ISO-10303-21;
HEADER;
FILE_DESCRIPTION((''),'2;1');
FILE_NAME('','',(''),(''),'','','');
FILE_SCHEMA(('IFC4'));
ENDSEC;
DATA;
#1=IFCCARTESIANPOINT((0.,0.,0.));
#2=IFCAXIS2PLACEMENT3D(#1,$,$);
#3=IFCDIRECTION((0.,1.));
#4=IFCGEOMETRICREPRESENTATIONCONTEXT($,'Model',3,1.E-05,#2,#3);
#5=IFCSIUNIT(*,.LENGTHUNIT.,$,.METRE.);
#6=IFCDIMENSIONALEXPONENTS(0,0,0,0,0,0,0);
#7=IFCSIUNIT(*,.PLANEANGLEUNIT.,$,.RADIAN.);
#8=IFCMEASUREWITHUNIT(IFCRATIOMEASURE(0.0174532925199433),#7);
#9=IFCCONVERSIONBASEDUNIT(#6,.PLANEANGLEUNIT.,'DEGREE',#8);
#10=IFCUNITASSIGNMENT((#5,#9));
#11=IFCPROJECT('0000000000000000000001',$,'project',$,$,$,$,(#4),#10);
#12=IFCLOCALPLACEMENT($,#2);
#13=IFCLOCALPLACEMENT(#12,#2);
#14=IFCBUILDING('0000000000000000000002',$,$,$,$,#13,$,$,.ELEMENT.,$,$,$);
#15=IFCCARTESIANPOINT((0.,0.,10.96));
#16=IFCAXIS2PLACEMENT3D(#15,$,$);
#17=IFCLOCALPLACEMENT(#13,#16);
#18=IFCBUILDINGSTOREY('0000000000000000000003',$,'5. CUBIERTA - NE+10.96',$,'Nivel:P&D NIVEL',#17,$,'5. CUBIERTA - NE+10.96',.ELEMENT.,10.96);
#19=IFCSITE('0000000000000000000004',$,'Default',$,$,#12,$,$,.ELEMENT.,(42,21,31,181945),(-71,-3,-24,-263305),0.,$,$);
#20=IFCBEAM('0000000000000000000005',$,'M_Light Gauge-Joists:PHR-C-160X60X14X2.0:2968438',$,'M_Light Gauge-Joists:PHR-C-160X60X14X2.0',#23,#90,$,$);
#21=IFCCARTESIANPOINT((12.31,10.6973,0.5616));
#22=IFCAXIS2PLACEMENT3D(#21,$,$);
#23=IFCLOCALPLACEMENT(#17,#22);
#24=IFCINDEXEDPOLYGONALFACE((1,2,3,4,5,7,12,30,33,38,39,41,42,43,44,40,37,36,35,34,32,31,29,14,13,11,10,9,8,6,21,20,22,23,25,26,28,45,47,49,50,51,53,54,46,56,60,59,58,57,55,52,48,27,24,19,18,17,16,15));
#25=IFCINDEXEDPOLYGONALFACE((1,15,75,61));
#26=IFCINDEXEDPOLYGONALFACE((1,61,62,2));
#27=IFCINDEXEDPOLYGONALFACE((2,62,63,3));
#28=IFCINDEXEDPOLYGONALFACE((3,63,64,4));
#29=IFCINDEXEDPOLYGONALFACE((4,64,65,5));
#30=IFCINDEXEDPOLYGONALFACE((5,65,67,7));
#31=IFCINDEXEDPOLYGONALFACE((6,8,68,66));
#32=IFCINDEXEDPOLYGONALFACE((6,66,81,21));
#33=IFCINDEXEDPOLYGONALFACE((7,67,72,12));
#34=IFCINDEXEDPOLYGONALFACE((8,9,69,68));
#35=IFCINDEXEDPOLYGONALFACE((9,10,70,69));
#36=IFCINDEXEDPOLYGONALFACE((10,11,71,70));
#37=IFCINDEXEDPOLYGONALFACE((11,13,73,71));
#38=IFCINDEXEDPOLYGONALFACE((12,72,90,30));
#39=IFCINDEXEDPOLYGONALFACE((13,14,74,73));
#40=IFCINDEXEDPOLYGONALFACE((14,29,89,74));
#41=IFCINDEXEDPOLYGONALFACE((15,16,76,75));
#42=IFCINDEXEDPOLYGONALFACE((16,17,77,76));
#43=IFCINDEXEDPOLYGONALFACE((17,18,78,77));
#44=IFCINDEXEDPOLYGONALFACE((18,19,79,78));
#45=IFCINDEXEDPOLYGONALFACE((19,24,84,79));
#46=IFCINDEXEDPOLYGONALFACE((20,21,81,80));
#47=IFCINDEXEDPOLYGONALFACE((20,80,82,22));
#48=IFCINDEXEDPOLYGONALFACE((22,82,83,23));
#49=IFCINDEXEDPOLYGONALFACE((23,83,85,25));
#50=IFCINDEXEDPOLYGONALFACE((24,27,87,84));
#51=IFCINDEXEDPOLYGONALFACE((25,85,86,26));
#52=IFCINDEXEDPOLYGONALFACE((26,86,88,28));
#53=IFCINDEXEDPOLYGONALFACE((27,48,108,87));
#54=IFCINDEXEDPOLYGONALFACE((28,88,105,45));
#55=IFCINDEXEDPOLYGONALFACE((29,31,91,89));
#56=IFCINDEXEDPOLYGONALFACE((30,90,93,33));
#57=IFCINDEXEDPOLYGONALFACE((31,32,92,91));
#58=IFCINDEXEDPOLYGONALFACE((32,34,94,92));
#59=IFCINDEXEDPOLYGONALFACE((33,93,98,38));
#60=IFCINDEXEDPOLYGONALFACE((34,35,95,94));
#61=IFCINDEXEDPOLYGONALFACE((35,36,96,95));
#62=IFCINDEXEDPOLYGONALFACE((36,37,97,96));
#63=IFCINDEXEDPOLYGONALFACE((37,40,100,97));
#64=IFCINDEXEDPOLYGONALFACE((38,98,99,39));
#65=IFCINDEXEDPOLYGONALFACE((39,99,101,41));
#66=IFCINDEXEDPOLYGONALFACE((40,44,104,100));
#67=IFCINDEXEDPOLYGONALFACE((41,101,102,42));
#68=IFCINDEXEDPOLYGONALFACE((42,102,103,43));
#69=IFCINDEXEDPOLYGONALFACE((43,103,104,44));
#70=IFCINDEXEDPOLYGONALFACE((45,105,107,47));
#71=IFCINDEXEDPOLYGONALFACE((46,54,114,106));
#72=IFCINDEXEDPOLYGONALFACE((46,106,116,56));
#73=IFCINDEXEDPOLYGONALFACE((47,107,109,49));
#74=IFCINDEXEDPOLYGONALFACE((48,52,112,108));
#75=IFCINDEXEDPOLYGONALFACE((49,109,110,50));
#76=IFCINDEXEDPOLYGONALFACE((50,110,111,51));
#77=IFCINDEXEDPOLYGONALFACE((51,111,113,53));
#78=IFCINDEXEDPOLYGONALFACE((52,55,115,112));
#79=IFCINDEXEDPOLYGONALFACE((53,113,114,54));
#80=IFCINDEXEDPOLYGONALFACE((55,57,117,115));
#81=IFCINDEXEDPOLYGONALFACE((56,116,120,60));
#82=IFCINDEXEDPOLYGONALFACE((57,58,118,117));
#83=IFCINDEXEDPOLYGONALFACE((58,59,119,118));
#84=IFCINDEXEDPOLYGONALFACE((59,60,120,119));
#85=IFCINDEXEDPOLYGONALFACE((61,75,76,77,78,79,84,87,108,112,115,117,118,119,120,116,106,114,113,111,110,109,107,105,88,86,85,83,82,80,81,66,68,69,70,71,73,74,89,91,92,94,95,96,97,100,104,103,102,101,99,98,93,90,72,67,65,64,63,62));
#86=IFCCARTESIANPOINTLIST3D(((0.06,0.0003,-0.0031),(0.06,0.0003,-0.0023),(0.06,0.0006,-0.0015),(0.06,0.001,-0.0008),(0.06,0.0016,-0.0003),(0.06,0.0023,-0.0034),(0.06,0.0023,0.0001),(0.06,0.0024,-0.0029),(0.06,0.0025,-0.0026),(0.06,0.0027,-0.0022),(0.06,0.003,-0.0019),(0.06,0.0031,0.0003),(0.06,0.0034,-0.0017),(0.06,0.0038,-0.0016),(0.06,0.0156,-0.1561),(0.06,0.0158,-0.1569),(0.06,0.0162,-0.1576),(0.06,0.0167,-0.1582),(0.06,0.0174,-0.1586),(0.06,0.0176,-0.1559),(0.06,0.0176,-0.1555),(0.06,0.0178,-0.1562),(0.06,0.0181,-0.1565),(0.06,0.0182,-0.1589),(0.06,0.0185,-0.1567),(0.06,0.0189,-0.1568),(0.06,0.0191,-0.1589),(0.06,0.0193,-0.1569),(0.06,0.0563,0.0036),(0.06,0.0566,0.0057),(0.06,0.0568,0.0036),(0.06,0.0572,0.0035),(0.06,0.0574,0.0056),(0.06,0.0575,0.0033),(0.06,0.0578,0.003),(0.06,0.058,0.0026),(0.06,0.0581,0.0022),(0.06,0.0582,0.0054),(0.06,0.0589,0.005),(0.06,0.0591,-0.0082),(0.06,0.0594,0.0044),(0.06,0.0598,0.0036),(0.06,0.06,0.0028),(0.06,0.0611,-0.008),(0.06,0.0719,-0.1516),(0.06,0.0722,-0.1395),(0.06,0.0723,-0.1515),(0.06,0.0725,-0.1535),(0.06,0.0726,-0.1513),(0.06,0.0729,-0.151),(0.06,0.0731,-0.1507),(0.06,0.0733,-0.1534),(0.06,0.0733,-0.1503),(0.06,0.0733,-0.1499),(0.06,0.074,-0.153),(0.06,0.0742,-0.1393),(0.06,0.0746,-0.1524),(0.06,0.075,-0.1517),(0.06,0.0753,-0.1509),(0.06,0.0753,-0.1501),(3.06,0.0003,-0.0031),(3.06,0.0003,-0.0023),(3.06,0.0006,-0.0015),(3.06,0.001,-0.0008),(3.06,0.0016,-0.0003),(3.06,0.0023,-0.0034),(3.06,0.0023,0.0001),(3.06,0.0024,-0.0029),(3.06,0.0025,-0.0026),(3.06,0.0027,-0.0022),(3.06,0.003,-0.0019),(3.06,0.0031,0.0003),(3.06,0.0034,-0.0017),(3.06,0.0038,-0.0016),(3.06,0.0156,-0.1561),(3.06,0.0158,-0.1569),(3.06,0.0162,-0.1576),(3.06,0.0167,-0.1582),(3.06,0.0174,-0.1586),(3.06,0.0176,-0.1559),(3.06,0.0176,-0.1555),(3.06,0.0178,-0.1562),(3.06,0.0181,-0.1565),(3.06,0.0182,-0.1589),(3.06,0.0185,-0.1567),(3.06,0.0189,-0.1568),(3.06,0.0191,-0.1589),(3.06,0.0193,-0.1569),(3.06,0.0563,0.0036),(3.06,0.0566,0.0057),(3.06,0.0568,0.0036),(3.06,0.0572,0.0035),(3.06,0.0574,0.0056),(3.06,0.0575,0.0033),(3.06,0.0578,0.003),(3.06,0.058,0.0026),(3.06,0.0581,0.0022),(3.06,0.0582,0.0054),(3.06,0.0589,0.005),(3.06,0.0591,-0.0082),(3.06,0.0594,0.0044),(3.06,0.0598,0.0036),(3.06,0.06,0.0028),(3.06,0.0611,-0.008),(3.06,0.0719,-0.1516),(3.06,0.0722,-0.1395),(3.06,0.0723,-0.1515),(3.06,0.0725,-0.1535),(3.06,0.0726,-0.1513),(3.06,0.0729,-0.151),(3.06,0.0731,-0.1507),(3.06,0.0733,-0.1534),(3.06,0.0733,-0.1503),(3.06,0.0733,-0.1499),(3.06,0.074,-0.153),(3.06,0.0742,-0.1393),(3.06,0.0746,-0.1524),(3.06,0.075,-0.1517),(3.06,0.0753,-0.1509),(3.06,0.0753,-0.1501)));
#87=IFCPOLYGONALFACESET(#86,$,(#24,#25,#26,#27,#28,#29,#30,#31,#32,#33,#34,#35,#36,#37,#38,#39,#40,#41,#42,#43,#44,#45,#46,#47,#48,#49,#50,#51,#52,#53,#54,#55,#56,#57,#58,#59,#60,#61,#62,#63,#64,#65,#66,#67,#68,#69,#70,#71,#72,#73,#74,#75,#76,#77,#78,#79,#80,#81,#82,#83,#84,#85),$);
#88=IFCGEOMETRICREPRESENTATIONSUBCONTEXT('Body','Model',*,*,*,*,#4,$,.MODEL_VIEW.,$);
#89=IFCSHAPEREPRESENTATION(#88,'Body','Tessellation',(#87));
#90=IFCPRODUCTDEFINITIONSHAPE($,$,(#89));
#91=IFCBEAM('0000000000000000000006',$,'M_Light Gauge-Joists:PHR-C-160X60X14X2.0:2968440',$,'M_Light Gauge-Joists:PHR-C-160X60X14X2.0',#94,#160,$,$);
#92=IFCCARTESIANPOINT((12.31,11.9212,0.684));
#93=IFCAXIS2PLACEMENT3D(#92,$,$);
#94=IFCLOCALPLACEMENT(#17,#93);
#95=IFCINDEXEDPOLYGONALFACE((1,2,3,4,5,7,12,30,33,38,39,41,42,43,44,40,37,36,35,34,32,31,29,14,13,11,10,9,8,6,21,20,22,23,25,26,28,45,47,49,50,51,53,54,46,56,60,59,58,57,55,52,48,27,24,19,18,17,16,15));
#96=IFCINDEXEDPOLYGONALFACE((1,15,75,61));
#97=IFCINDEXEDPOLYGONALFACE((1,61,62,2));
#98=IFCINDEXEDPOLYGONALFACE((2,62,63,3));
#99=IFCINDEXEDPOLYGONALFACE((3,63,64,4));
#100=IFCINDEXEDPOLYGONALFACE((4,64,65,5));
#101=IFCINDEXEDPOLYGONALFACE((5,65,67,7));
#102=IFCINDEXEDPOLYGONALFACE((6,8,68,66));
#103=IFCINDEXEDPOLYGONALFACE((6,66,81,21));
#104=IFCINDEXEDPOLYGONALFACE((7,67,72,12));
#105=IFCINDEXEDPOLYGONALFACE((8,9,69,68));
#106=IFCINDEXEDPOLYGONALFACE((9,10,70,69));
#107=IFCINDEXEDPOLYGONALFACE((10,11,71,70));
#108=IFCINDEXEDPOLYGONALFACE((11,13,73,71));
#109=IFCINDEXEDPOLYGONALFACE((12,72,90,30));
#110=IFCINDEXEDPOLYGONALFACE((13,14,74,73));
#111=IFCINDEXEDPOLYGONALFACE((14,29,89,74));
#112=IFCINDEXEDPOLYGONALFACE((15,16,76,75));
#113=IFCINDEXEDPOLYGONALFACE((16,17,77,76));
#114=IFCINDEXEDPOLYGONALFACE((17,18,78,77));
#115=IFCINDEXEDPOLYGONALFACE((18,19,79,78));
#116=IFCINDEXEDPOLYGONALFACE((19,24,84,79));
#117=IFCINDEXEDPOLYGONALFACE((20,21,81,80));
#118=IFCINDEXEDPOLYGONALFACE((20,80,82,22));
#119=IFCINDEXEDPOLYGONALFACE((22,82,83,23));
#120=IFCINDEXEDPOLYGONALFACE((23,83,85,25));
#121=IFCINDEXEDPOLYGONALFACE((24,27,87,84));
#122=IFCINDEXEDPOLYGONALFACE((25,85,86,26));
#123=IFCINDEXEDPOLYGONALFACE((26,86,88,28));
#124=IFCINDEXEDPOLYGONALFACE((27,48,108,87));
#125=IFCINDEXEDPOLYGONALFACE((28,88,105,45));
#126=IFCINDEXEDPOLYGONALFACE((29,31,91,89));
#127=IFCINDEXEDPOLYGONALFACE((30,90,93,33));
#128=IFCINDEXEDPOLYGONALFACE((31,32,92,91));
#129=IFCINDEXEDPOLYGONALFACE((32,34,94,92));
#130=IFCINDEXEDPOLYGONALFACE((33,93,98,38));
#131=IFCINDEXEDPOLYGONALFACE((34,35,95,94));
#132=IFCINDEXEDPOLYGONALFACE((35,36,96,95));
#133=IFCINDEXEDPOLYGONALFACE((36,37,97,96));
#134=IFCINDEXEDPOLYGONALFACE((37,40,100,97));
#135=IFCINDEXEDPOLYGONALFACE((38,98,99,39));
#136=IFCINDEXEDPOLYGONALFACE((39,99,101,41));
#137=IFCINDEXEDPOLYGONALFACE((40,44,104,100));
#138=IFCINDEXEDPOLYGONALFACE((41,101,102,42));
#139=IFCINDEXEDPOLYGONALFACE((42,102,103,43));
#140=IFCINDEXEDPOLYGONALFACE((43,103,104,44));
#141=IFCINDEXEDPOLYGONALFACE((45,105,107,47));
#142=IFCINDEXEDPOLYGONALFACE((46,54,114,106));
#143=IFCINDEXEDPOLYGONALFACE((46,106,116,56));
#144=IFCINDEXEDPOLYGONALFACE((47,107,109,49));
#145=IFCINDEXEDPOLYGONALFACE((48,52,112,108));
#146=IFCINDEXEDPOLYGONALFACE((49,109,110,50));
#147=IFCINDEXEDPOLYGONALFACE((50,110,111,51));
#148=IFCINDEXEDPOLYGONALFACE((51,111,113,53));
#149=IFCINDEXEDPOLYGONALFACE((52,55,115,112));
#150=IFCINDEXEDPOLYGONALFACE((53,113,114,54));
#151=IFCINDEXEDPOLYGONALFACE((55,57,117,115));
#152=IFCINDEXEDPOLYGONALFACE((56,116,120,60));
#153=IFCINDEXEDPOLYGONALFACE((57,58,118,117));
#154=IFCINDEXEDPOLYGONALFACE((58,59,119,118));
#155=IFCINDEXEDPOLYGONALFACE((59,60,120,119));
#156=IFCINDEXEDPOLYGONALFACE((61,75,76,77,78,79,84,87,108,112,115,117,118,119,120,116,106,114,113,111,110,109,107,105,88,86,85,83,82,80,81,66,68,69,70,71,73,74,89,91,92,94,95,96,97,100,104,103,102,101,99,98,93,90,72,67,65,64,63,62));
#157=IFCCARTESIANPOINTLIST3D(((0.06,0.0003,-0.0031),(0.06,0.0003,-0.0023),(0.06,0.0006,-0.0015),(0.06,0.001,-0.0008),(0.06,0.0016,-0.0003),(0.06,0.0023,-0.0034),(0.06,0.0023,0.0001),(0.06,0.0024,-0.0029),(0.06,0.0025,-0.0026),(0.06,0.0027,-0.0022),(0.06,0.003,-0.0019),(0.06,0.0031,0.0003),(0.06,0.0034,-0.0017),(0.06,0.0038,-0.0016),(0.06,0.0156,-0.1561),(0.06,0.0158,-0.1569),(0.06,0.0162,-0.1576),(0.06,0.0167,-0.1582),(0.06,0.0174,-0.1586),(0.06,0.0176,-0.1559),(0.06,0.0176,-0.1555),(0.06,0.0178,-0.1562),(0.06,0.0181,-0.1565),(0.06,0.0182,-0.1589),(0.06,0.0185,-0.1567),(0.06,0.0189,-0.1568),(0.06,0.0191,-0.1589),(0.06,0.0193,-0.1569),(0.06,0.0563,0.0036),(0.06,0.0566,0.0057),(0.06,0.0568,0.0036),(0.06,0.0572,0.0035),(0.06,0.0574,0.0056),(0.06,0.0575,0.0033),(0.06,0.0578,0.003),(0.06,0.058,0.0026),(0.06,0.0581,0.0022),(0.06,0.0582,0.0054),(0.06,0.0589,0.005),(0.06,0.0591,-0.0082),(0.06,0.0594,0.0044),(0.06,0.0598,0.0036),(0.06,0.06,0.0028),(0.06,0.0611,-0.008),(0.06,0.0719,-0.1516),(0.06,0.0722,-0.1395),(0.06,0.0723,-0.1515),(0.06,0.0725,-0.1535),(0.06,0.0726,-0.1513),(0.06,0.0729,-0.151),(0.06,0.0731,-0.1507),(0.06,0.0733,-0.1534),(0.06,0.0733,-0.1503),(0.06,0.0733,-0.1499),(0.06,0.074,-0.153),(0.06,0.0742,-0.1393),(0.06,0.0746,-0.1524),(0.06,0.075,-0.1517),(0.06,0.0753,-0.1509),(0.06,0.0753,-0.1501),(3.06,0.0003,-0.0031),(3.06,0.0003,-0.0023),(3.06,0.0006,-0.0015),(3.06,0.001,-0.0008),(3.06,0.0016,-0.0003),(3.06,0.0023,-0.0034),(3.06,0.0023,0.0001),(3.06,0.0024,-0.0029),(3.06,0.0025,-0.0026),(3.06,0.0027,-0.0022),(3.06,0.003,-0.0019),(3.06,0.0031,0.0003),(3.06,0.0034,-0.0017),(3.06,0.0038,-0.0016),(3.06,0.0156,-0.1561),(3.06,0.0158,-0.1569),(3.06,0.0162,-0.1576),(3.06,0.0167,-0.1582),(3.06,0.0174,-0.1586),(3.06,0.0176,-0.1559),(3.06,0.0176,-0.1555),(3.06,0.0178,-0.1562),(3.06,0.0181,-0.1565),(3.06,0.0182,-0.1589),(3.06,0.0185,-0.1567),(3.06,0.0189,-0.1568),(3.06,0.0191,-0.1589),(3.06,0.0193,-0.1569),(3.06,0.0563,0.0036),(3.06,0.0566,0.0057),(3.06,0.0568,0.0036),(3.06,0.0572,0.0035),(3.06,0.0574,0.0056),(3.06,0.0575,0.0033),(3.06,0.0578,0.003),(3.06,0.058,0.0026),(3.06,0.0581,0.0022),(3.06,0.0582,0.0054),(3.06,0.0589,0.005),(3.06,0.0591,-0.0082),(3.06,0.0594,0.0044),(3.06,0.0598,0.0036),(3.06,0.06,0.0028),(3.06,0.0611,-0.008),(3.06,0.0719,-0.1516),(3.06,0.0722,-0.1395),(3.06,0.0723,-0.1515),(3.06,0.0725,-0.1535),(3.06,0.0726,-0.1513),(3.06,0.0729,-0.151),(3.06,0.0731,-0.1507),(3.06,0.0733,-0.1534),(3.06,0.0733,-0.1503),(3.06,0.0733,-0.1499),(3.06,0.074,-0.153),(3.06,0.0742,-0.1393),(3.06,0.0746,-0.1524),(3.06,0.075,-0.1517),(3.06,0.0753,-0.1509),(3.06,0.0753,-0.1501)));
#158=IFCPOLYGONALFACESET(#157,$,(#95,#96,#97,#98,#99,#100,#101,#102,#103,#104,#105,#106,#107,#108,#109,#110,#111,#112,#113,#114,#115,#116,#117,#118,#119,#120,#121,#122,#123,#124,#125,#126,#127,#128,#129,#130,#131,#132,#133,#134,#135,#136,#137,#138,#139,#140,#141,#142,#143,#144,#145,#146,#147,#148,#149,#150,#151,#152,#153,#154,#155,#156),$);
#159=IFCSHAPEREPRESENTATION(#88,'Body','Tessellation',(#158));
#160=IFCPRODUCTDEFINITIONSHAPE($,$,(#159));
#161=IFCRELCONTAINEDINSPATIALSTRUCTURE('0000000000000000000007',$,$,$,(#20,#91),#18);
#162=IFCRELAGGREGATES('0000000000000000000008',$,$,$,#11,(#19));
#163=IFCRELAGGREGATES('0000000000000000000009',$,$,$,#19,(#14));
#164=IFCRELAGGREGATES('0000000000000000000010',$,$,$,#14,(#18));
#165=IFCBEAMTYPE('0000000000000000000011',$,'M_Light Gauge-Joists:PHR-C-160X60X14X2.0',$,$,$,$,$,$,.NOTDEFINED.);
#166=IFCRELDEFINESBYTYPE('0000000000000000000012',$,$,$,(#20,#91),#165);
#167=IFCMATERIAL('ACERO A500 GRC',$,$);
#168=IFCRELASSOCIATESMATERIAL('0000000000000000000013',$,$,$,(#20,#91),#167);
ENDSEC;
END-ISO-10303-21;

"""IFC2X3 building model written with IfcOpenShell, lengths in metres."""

from ifc_helpers import new_model, entity, si_unit, converted_unit, direction, frame, frame_2d, origin, place, context, subcontext, project, spatial, polyline, circle_curve, parameter, trimmed, segment, composite_curve, outline, extrude, material, type_object, element, save


model = new_model("IFC2X3")

# Units and contexts
model_context = context("Model", 3, precision=1e-05, world=origin(), true_north=direction((0.0, 1.0)))
body_context = subcontext(model_context, "Body", "Model", "MODEL_VIEW")
ifc_project = project(units=[si_unit("LENGTHUNIT", "METRE"), converted_unit("PLANEANGLEUNIT", "DEGREE", entity("IfcRatioMeasure", 0.0174532925199433), si_unit("PLANEANGLEUNIT", "RADIAN"), dimensions=[0, 0, 0, 0, 0, 0, 0])], contexts=[model_context])

# Site, building, storey
site_placement = place(None, origin())
site = spatial("IfcSite", under=ifc_project, at=site_placement, Name="Default", CompositionType="ELEMENT", RefLatitude=(42, 21, 31, 181945), RefLongitude=(-71, -3, -24, -263305), RefElevation=0.0)
building_placement = place(site_placement, origin())
building = spatial("IfcBuilding", under=site, at=building_placement, CompositionType="ELEMENT")
storey_placement = place(building_placement, frame((0.0, 0.0, 10.96)))
storey = spatial("IfcBuildingStorey", under=building, at=storey_placement, Name="5. CUBIERTA - NE+10.96", ObjectType="Nivel:P&D NIVEL", LongName="5. CUBIERTA - NE+10.96", CompositionType="ELEMENT", Elevation=10.96)

# Beams
ifc_material_1 = material(Name="ACERO A500 GRC")
beam_type_1 = type_object("IfcBeamType", Name="M_Light Gauge-Joists:PHR-C-160X60X14X2.0", PredefinedType="NOTDEFINED")
beam_1_placement = place(storey_placement, frame((12.31, 10.6973, 0.5616)))
element("IfcBeam", 1, at=beam_1_placement, inside=storey, type_object=beam_type_1, material=ifc_material_1, Name="M_Light Gauge-Joists:PHR-C-160X60X14X2.0:2968438", ObjectType="M_Light Gauge-Joists:PHR-C-160X60X14X2.0", context=body_context, shape_type="SweptSolid", body=[
    extrude(outline(composite_curve([segment(trimmed(circle_curve(frame_2d((-0.0764, -0.0322), x_axis=(-1.0, 0.0)), 0.0016), [parameter(0.0)], [parameter(90.0)], True, "PARAMETER"), False, "CONTINUOUS"), segment(polyline([(-0.078, -0.0322), (-0.078, 0.0206)]), True, "CONTINUOUS"), segment(trimmed(circle_curve(frame_2d((-0.0764, 0.0206), x_axis=(0.0, 1.0)), 0.0016), [parameter(0.0)], [parameter(90.0)], True, "PARAMETER"), False, "CONTINUOUS"), segment(polyline([(-0.0764, 0.0222), (-0.066, 0.0222)]), True, "CONTINUOUS"), segment(polyline([(-0.066, 0.0222), (-0.066, 0.0242)]), True, "CONTINUOUS"), segment(polyline([(-0.066, 0.0242), (-0.0768, 0.0242)]), True, "CONTINUOUS"), segment(trimmed(circle_curve(frame_2d((-0.0768, 0.021), x_axis=(-1.0, 0.0)), 0.0032), [parameter(270.0)], [parameter(0.0)], True, "PARAMETER"), True, "CONTINUOUS"), segment(polyline([(-0.08, 0.021), (-0.08, -0.0326)]), True, "CONTINUOUS"), segment(trimmed(circle_curve(frame_2d((-0.0768, -0.0326), x_axis=(0.0, -1.0)), 0.0032), [parameter(270.0)], [parameter(0.0)], True, "PARAMETER"), True, "CONTINUOUS"), segment(polyline([(-0.0768, -0.0358), (0.0768, -0.0358)]), True, "CONTINUOUS"), segment(trimmed(circle_curve(frame_2d((0.0768, -0.0326), x_axis=(1.0, 0.0)), 0.0032), [parameter(270.0)], [parameter(0.0)], True, "PARAMETER"), True, "CONTINUOUS"), segment(polyline([(0.08, -0.0326), (0.08, 0.021)]), True, "CONTINUOUS"), segment(trimmed(circle_curve(frame_2d((0.0768, 0.021), x_axis=(0.0, 1.0)), 0.0032), [parameter(270.0)], [parameter(0.0)], True, "PARAMETER"), True, "CONTINUOUS"), segment(polyline([(0.0768, 0.0242), (0.066, 0.0242)]), True, "CONTINUOUS"), segment(polyline([(0.066, 0.0242), (0.066, 0.0222)]), True, "CONTINUOUS"), segment(polyline([(0.066, 0.0222), (0.0764, 0.0222)]), True, "CONTINUOUS"), segment(trimmed(circle_curve(frame_2d((0.0764, 0.0206), x_axis=(1.0, 0.0)), 0.0016), [parameter(0.0)], [parameter(90.0)], True, "PARAMETER"), False, "CONTINUOUS"), segment(polyline([(0.078, 0.0206), (0.078, -0.0322)]), True, "CONTINUOUS"), segment(trimmed(circle_curve(frame_2d((0.0764, -0.0322), x_axis=(0.0, -1.0)), 0.0016), [parameter(0.0)], [parameter(90.0)], True, "PARAMETER"), False, "CONTINUOUS"), segment(polyline([(0.0764, -0.0338), (-0.0764, -0.0338)]), True, "CONTINUOUS")], self_intersect=False)), frame((0.06, 0.0436, -0.076), z_axis=(-1.0, 0.0, 0.0), x_axis=(0.0, -0.099504, 0.995037)), (0.0, 0.0, -1.0), 3.0),
])
beam_2_placement = place(storey_placement, frame((12.31, 11.9212, 0.684)))
element("IfcBeam", 2, at=beam_2_placement, inside=storey, type_object=beam_type_1, material=ifc_material_1, Name="M_Light Gauge-Joists:PHR-C-160X60X14X2.0:2968440", ObjectType="M_Light Gauge-Joists:PHR-C-160X60X14X2.0", context=body_context, shape_type="SweptSolid", body=[
    extrude(outline(composite_curve([segment(trimmed(circle_curve(frame_2d((-0.0764, -0.0322), x_axis=(-1.0, 0.0)), 0.0016), [parameter(0.0)], [parameter(90.0)], True, "PARAMETER"), False, "CONTINUOUS"), segment(polyline([(-0.078, -0.0322), (-0.078, 0.0206)]), True, "CONTINUOUS"), segment(trimmed(circle_curve(frame_2d((-0.0764, 0.0206), x_axis=(0.0, 1.0)), 0.0016), [parameter(0.0)], [parameter(90.0)], True, "PARAMETER"), False, "CONTINUOUS"), segment(polyline([(-0.0764, 0.0222), (-0.066, 0.0222)]), True, "CONTINUOUS"), segment(polyline([(-0.066, 0.0222), (-0.066, 0.0242)]), True, "CONTINUOUS"), segment(polyline([(-0.066, 0.0242), (-0.0768, 0.0242)]), True, "CONTINUOUS"), segment(trimmed(circle_curve(frame_2d((-0.0768, 0.021), x_axis=(-1.0, 0.0)), 0.0032), [parameter(270.0)], [parameter(0.0)], True, "PARAMETER"), True, "CONTINUOUS"), segment(polyline([(-0.08, 0.021), (-0.08, -0.0326)]), True, "CONTINUOUS"), segment(trimmed(circle_curve(frame_2d((-0.0768, -0.0326), x_axis=(0.0, -1.0)), 0.0032), [parameter(270.0)], [parameter(0.0)], True, "PARAMETER"), True, "CONTINUOUS"), segment(polyline([(-0.0768, -0.0358), (0.0768, -0.0358)]), True, "CONTINUOUS"), segment(trimmed(circle_curve(frame_2d((0.0768, -0.0326), x_axis=(1.0, 0.0)), 0.0032), [parameter(270.0)], [parameter(0.0)], True, "PARAMETER"), True, "CONTINUOUS"), segment(polyline([(0.08, -0.0326), (0.08, 0.021)]), True, "CONTINUOUS"), segment(trimmed(circle_curve(frame_2d((0.0768, 0.021), x_axis=(0.0, 1.0)), 0.0032), [parameter(270.0)], [parameter(0.0)], True, "PARAMETER"), True, "CONTINUOUS"), segment(polyline([(0.0768, 0.0242), (0.066, 0.0242)]), True, "CONTINUOUS"), segment(polyline([(0.066, 0.0242), (0.066, 0.0222)]), True, "CONTINUOUS"), segment(polyline([(0.066, 0.0222), (0.0764, 0.0222)]), True, "CONTINUOUS"), segment(trimmed(circle_curve(frame_2d((0.0764, 0.0206), x_axis=(1.0, 0.0)), 0.0016), [parameter(0.0)], [parameter(90.0)], True, "PARAMETER"), False, "CONTINUOUS"), segment(polyline([(0.078, 0.0206), (0.078, -0.0322)]), True, "CONTINUOUS"), segment(trimmed(circle_curve(frame_2d((0.0764, -0.0322), x_axis=(0.0, -1.0)), 0.0016), [parameter(0.0)], [parameter(90.0)], True, "PARAMETER"), False, "CONTINUOUS"), segment(polyline([(0.0764, -0.0338), (-0.0764, -0.0338)]), True, "CONTINUOUS")], self_intersect=False)), frame((0.06, 0.0436, -0.076), z_axis=(-1.0, 0.0, 0.0), x_axis=(0.0, -0.099504, 0.995037)), (0.0, 0.0, -1.0), 3.0),
])

save(model, "model.ifc")
